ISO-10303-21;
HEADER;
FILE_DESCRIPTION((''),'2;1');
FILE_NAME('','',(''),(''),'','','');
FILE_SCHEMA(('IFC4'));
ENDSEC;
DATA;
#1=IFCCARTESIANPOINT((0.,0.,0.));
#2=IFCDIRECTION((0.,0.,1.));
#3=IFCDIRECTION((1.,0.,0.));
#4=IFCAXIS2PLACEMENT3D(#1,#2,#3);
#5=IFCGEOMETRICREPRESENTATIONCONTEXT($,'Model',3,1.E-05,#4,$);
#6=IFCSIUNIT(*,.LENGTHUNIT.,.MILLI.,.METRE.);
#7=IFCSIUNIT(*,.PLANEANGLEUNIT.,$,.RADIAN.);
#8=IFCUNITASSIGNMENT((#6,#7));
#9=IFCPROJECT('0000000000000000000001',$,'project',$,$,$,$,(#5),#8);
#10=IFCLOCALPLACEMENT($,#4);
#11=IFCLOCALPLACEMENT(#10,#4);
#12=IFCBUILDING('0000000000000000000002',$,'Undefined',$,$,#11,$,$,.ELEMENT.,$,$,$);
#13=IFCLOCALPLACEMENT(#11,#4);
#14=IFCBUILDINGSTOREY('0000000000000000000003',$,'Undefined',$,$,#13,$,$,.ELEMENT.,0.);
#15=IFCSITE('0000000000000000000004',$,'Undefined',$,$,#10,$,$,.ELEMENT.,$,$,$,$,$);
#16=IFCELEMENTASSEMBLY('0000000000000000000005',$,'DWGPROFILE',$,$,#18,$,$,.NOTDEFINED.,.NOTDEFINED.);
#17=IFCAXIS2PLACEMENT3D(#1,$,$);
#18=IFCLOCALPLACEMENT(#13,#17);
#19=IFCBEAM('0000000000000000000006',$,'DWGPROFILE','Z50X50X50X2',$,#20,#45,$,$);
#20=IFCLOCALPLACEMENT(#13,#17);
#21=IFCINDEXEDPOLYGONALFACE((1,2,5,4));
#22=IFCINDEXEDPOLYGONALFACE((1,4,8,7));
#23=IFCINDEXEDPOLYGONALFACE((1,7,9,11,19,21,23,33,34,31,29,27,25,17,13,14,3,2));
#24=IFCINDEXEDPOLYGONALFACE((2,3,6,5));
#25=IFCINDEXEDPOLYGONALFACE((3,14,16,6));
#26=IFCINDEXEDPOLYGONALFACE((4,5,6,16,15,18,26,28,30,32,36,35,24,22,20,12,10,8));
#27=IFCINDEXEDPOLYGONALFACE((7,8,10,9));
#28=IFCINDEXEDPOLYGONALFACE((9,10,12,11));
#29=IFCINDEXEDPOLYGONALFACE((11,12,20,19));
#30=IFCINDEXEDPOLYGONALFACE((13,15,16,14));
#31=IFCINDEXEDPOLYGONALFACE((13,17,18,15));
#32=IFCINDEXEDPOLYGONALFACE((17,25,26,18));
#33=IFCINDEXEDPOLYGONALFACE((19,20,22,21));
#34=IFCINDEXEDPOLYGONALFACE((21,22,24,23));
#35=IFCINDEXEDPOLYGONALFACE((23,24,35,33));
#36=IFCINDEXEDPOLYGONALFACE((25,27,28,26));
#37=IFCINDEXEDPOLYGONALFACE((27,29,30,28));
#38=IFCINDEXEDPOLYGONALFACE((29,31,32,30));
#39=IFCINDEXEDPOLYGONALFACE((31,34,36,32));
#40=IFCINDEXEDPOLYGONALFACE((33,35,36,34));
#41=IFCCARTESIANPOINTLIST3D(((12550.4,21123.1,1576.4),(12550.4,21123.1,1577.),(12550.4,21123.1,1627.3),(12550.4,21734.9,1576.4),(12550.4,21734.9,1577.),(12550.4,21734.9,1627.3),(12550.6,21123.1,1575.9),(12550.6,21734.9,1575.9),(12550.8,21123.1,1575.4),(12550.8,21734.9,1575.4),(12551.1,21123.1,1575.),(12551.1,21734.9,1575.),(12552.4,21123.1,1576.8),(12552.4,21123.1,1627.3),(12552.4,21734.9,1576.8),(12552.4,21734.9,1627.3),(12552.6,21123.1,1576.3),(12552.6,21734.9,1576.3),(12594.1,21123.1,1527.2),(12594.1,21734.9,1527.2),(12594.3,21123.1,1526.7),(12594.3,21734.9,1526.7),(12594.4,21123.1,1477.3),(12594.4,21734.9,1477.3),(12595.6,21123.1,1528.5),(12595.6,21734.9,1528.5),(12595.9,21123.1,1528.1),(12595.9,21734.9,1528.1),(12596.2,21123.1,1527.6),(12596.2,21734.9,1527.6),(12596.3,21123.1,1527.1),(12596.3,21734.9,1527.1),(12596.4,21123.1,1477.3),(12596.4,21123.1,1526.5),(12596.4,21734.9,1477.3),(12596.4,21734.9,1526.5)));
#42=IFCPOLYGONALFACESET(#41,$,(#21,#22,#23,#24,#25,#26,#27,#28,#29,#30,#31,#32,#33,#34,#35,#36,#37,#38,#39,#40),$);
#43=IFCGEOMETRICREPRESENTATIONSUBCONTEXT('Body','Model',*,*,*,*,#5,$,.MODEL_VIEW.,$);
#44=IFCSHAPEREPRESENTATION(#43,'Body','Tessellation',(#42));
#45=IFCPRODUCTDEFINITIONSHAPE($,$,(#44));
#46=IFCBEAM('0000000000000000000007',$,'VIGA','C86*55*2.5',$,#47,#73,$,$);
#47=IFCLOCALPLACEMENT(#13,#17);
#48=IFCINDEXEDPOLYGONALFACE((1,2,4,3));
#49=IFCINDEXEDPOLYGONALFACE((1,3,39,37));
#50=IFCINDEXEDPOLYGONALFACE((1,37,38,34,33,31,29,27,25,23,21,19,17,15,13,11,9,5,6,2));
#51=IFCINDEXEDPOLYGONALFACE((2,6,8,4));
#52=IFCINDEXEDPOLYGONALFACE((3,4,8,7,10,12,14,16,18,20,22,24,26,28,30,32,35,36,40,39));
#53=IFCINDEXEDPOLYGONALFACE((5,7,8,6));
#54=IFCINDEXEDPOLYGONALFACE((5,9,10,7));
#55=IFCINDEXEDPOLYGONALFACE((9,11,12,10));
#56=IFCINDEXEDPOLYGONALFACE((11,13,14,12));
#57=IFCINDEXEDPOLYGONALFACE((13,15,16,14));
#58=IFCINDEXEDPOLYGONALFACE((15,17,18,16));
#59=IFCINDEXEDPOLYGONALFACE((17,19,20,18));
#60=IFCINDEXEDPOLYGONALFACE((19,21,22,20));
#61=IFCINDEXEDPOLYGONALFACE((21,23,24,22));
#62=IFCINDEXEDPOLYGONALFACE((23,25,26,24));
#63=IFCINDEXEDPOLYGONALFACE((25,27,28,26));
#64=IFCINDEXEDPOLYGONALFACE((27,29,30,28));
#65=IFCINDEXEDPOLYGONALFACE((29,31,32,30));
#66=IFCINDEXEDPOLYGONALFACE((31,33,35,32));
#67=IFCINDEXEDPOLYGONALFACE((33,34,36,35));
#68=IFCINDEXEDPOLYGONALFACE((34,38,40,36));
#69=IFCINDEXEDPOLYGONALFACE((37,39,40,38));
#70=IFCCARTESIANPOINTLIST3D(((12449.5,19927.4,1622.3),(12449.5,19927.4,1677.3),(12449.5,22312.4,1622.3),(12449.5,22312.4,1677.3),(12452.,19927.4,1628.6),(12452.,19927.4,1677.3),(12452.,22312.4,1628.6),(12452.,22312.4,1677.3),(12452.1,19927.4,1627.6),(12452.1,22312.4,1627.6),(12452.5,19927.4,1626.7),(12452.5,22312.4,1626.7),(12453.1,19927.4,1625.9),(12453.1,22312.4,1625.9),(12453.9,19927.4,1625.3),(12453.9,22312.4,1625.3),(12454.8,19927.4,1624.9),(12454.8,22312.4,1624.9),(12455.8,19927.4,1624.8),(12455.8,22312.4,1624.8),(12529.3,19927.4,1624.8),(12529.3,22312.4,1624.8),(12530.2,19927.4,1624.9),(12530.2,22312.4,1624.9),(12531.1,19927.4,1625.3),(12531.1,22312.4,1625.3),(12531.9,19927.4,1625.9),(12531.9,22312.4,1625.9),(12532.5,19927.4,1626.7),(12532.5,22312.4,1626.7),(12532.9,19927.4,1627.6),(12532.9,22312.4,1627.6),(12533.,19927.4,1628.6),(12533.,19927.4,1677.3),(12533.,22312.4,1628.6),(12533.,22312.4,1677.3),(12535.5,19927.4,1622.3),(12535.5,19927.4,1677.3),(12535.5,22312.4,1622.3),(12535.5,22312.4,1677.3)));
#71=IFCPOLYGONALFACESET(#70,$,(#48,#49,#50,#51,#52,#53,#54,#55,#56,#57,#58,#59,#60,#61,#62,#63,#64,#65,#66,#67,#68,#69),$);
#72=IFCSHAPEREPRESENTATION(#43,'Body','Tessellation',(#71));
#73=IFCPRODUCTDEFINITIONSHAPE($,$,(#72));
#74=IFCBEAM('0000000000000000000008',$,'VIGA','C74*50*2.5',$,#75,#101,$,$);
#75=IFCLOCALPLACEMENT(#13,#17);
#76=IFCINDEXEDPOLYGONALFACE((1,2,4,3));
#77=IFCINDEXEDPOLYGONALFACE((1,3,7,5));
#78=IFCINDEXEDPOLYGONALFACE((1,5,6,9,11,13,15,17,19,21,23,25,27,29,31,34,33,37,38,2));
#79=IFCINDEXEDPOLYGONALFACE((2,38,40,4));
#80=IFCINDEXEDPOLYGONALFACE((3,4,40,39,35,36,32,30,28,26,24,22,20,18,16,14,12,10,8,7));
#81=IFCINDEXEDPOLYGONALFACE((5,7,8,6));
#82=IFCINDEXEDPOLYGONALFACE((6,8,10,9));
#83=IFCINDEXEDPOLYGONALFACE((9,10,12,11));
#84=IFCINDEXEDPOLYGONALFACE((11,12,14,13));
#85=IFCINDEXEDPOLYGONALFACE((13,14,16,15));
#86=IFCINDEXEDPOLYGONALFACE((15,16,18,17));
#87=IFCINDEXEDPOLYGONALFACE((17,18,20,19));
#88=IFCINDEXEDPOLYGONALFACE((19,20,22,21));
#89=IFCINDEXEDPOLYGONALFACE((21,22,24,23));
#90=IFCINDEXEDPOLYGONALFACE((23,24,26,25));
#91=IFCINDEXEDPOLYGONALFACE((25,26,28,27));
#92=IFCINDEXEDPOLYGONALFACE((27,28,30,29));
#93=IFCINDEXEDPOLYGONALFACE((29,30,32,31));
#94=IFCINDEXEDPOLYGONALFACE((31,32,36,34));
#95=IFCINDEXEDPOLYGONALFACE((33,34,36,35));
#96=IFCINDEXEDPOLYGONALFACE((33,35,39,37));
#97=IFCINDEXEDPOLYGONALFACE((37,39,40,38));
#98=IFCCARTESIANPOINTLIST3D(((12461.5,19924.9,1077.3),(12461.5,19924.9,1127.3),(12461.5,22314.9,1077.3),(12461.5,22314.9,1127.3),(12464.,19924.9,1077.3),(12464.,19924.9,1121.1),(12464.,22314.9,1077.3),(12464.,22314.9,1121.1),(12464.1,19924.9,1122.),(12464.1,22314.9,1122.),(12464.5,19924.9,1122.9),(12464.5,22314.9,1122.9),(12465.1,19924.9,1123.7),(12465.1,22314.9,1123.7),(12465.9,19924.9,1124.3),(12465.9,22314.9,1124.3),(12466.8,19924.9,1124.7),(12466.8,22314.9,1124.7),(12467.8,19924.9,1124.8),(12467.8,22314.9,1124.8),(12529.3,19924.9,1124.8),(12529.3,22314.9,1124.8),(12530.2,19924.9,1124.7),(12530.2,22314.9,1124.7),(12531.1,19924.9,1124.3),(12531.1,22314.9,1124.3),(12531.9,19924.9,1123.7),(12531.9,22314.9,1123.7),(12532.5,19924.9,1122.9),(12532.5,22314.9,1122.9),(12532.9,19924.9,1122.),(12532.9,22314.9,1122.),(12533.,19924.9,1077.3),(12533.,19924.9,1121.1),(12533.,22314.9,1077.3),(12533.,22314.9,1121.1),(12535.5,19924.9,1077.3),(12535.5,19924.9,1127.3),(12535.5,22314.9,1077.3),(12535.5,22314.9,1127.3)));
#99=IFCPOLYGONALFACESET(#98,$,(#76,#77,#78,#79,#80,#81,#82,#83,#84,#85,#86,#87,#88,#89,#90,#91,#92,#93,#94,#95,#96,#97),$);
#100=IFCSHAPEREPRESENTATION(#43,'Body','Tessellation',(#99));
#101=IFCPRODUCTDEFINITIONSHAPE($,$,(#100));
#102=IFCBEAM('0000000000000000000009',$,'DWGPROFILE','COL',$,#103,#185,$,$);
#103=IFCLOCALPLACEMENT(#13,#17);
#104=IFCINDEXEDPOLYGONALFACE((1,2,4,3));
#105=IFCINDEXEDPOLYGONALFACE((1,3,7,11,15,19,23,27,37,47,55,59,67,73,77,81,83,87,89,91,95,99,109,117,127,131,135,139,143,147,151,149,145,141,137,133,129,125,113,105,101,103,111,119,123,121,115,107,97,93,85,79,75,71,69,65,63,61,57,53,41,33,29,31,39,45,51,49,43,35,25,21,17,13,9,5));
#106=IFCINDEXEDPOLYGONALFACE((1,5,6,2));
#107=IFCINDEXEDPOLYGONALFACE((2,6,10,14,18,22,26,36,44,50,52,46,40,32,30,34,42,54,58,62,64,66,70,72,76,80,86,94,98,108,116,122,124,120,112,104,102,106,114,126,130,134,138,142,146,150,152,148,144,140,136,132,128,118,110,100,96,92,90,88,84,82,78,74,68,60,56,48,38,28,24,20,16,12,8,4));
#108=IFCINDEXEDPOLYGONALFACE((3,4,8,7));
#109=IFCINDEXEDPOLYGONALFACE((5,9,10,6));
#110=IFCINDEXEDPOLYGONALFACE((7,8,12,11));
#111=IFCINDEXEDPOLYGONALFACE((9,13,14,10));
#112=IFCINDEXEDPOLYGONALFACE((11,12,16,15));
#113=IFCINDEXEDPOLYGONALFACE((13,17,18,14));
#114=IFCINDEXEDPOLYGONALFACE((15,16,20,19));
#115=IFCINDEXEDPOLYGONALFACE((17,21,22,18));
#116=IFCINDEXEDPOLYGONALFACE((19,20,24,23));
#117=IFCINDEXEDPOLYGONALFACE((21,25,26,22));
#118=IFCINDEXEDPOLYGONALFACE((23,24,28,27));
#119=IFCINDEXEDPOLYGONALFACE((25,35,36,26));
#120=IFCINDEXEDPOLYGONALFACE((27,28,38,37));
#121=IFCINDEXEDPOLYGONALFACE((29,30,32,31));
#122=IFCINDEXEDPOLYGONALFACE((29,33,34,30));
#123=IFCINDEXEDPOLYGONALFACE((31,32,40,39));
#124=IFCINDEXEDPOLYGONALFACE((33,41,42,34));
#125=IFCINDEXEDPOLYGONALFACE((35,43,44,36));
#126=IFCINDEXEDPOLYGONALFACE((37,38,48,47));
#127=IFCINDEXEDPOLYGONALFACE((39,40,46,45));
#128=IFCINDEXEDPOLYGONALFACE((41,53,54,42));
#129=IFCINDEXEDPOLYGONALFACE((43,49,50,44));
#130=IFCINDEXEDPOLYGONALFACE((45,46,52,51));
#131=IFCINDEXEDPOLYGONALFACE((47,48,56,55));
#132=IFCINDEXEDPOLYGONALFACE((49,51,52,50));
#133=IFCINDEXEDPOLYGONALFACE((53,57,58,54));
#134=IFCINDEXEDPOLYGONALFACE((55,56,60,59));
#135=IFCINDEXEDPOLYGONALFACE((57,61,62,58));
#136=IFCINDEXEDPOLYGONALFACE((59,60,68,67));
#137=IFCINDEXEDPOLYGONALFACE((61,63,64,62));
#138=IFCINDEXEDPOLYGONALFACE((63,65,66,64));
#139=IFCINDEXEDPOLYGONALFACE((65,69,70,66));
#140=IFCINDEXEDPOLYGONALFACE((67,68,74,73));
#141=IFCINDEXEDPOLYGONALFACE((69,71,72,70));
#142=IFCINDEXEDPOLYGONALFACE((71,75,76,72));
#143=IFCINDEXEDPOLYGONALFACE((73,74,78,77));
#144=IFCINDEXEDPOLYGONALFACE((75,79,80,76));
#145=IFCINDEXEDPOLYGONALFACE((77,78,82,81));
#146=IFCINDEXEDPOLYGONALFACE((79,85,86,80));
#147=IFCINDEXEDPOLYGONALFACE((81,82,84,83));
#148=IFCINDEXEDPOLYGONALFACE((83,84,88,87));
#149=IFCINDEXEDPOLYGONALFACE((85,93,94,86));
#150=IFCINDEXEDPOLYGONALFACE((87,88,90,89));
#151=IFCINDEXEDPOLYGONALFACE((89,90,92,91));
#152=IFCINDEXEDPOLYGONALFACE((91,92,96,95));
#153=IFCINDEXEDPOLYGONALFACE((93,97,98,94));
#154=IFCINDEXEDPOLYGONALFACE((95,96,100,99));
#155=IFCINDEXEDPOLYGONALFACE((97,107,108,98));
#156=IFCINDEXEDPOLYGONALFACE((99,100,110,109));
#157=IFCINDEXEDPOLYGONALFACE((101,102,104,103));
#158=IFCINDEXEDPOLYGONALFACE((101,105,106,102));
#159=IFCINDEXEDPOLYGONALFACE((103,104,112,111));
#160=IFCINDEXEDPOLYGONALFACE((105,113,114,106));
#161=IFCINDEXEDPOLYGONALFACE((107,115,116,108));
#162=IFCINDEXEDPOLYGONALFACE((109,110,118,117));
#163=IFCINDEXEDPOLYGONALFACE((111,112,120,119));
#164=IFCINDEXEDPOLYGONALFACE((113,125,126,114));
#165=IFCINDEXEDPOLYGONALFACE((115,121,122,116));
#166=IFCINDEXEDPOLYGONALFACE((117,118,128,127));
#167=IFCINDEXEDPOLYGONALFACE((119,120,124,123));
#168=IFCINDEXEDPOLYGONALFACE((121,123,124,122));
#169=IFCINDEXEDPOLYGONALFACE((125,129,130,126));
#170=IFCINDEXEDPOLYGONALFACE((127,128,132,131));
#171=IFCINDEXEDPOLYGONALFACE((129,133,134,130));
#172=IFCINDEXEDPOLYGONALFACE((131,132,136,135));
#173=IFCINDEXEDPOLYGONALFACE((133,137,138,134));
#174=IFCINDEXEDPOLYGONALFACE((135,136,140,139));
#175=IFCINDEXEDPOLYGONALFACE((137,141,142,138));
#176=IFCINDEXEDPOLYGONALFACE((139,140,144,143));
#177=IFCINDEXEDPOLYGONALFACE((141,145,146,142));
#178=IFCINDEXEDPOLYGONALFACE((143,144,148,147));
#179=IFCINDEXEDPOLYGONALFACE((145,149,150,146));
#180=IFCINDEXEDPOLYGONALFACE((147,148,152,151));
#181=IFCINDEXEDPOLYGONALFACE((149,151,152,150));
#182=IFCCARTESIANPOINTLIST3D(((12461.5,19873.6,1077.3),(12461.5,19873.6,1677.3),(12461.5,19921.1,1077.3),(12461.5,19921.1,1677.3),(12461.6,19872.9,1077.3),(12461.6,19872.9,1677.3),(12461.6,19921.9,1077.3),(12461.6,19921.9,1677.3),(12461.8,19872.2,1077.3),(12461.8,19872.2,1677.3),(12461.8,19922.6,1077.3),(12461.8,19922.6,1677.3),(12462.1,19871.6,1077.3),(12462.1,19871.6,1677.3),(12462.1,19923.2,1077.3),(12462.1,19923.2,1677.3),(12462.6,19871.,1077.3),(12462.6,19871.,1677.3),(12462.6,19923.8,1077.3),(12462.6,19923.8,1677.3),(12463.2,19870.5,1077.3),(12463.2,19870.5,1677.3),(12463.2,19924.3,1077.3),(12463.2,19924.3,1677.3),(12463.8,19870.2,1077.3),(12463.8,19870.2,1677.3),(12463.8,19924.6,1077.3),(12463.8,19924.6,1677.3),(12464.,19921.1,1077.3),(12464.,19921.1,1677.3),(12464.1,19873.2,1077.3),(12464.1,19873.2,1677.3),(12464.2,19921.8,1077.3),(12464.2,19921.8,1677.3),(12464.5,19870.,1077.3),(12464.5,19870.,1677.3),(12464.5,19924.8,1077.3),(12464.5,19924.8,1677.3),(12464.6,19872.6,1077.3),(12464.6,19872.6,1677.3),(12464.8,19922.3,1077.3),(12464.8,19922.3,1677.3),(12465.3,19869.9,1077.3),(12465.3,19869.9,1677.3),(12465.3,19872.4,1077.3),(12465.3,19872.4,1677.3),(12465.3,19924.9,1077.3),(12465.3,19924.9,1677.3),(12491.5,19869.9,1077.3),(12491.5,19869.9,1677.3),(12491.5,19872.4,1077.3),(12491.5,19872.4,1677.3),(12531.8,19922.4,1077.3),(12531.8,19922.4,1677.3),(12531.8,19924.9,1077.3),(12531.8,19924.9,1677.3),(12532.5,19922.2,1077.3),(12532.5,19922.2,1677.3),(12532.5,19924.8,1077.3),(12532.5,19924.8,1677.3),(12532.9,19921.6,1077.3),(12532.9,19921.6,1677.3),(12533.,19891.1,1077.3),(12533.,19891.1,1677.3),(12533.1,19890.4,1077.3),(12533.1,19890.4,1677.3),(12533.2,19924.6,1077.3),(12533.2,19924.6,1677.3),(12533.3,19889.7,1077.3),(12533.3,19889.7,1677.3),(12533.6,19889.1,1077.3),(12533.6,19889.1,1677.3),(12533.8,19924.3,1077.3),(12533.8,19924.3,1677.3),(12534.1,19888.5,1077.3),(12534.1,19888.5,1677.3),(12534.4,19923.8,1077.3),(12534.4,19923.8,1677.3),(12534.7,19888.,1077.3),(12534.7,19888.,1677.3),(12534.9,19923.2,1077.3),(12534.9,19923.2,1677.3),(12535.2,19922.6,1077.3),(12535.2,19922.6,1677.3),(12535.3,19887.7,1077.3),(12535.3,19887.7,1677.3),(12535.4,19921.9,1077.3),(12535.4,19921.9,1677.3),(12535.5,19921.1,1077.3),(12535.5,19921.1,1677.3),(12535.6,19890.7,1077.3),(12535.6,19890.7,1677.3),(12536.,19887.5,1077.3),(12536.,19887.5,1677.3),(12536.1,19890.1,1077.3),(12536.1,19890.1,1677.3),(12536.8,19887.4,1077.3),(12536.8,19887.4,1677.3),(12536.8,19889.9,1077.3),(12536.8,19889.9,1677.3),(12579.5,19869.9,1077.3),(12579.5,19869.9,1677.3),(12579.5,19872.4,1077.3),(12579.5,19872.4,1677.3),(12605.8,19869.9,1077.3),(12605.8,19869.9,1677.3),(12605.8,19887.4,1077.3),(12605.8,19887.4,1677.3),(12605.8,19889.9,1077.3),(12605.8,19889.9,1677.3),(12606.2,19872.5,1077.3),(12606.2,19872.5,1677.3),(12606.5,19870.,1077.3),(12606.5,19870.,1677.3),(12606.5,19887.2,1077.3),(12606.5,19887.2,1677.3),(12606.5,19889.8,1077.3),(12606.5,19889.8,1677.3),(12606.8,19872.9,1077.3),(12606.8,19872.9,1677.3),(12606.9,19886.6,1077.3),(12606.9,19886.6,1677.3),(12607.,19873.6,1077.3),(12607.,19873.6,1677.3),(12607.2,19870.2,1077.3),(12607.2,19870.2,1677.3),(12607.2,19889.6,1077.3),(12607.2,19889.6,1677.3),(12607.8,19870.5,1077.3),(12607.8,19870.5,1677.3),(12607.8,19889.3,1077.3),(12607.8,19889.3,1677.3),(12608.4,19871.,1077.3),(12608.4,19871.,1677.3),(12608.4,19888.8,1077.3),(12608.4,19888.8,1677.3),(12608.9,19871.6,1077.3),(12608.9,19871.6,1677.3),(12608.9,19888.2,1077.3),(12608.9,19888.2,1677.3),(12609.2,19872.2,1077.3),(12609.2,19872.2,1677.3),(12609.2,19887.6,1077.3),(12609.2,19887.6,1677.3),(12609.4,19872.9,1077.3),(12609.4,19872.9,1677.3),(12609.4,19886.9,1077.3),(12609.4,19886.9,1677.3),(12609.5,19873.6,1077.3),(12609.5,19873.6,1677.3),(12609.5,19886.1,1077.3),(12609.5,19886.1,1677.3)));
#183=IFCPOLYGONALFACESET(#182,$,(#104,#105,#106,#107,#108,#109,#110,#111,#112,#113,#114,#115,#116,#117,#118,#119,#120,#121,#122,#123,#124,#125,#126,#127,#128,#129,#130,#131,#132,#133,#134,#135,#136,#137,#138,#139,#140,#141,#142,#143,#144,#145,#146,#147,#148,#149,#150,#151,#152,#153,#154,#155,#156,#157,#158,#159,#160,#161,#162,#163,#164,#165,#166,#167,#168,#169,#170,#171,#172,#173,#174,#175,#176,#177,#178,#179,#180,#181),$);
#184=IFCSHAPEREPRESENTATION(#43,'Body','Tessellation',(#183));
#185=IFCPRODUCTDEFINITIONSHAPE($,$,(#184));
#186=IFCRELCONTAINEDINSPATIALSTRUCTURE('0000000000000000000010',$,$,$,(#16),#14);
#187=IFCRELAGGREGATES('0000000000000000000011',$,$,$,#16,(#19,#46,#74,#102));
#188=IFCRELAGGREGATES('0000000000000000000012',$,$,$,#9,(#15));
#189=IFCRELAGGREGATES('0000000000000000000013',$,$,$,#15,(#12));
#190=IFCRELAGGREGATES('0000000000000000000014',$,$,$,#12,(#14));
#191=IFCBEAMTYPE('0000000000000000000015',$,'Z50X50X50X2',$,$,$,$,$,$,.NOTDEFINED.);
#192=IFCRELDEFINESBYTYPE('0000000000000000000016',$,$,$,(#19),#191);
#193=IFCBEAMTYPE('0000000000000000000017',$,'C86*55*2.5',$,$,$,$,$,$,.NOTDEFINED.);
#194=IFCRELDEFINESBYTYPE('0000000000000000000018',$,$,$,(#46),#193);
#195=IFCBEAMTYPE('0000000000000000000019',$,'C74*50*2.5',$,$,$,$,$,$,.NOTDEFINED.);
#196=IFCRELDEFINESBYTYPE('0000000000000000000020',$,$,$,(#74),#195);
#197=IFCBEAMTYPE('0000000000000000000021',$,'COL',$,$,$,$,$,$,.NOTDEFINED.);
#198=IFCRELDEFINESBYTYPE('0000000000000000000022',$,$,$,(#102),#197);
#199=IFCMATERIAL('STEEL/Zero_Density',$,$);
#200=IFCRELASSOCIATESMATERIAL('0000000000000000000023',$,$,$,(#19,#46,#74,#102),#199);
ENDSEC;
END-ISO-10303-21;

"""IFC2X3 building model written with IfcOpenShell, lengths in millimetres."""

from ifc_helpers import new_model, si_unit, frame, origin_with_axes, origin_2d_with_axis, place, context, subcontext, project, spatial, polyline, u_section, outline, extrude, material, type_object, element, aggregate, save


model = new_model("IFC2X3")

# Units and contexts
model_context = context("Model", 3, precision=1e-05, world=origin_with_axes())
body_context = subcontext(model_context, "Body", "Model", "MODEL_VIEW")
ifc_project = project(units=[si_unit("LENGTHUNIT", "METRE", prefix="MILLI"), si_unit("PLANEANGLEUNIT", "RADIAN")], contexts=[model_context])

# Site, building, storey
site_placement = place(None, origin_with_axes())
site = spatial("IfcSite", under=ifc_project, at=site_placement, Name="Undefined", CompositionType="ELEMENT")
building_placement = place(site_placement, origin_with_axes())
building = spatial("IfcBuilding", under=site, at=building_placement, Name="Undefined", CompositionType="ELEMENT")
storey_placement = place(building_placement, origin_with_axes())
storey = spatial("IfcBuildingStorey", under=building, at=storey_placement, Name="Undefined", CompositionType="ELEMENT", Elevation=0.0)

# Element assembly, beams
assembly_1_placement = place(storey_placement, origin_with_axes())
assembly_1 = element("IfcElementAssembly", 1, at=assembly_1_placement, inside=storey, Name="DWGPROFILE", AssemblyPlace="NOTDEFINED", PredefinedType="NOTDEFINED")
ifc_material_1 = material(Name="STEEL/Zero_Density")
beam_type_1 = type_object("IfcBeamType", Name="Z50X50X50X2", PredefinedType="NOTDEFINED")
beam_1_placement = place(assembly_1_placement, frame((12573.4, 21123.1, 1552.3), z_axis=(0.0, 0.0, 1.0), x_axis=(0.0, 1.0, 0.0)))
beam_1 = element("IfcBeam", 2, at=beam_1_placement, type_object=beam_type_1, material=ifc_material_1, Name="DWGPROFILE", Description="Z50X50X50X2", context=body_context, shape_type="SweptSolid", body=[
    extrude(outline(polyline([(-22.9, 24.1), (-23.0, 24.7), (-23.0, 75.0), (-21.0, 75.0), (-21.0, 24.5), (-20.7, 24.0), (22.2, -23.8), (22.6, -24.2), (22.8, -24.7), (22.9, -25.2), (23.0, -25.8), (23.0, -75.0), (21.0, -75.0), (21.0, -25.6), (20.7, -25.1), (-22.2, 22.6), (-22.6, 23.1), (-22.8, 23.6), (-22.9, 24.1)])), frame((611.8, 0.0, 0.0), z_axis=(-1.0, 0.0, 0.0), x_axis=(0.0, -1.0, 0.0)), (0.0, 0.0, 1.0), 611.8),
])
beam_type_2 = type_object("IfcBeamType", Name="C86*55*2.5", PredefinedType="NOTDEFINED")
beam_2_placement = place(assembly_1_placement, frame((12492.5, 19927.4, 1649.8), z_axis=(-1.0, 0.0, 0.0), x_axis=(0.0, 1.0, 0.0)))
beam_2 = element("IfcBeam", 3, at=beam_2_placement, type_object=beam_type_2, material=ifc_material_1, Name="VIGA", Description="C86*55*2.5", context=body_context, shape_type="SweptSolid", body=[
    extrude(u_section(Depth=86.0, FlangeWidth=55.0, WebThickness=2.5, FlangeThickness=2.5, FilletRadius=3.8, at=origin_2d_with_axis()), frame((2385.0, 0.0, 0.0), z_axis=(-1.0, 0.0, 0.0), x_axis=(0.0, -1.0, 0.0)), (0.0, 0.0, 1.0), 2385.0),
])
beam_type_3 = type_object("IfcBeamType", Name="C74*50*2.5", PredefinedType="NOTDEFINED")
beam_3_placement = place(assembly_1_placement, frame((12498.5, 19924.9, 1102.3), z_axis=(1.0, 0.0, 0.0), x_axis=(0.0, 1.0, 0.0)))
beam_3 = element("IfcBeam", 4, at=beam_3_placement, type_object=beam_type_3, material=ifc_material_1, Name="VIGA", Description="C74*50*2.5", context=body_context, shape_type="SweptSolid", body=[
    extrude(u_section(Depth=74.0, FlangeWidth=50.0, WebThickness=2.5, FlangeThickness=2.5, FilletRadius=3.8, at=origin_2d_with_axis()), frame((2390.0, 0.0, 0.0), z_axis=(-1.0, 0.0, 0.0), x_axis=(0.0, -1.0, 0.0)), (0.0, 0.0, 1.0), 2390.0),
])
beam_type_4 = type_object("IfcBeamType", Name="COL", PredefinedType="NOTDEFINED")
beam_4_placement = place(assembly_1_placement, frame((12535.5, 19897.4, 1677.3), z_axis=(-1.0, 0.0, 0.0), x_axis=(0.0, 0.000001, -1.0)))
beam_4 = element("IfcBeam", 5, at=beam_4_placement, type_object=beam_type_4, material=ifc_material_1, Name="DWGPROFILE", Description="COL", context=body_context, shape_type="SweptSolid", body=[
    extrude(outline(polyline([(27.5, 70.2), (27.5, 3.8), (27.4, 3.0), (27.2, 2.3), (26.9, 1.7), (26.4, 1.1), (25.8, 0.6), (25.2, 0.3), (24.5, 0.1), (23.8, 0.0), (-6.7, -0.1), (-7.3, -0.6), (-7.5, -1.2), (-7.5, -70.2), (-7.6, -71.0), (-7.8, -71.7), (-8.1, -72.3), (-8.6, -72.9), (-9.2, -73.4), (-9.8, -73.7), (-10.5, -73.9), (-11.2, -74.0), (-23.8, -74.0), (-24.5, -73.9), (-25.2, -73.7), (-25.8, -73.4), (-26.4, -72.9), (-26.9, -72.3), (-27.2, -71.7), (-27.4, -71.0), (-27.5, -70.2), (-27.5, -44.0), (-25.0, -44.0), (-24.9, -70.7), (-24.4, -71.3), (-23.8, -71.5), (-10.8, -71.4), (-10.2, -70.9), (-10.0, -70.2), (-10.0, -1.2), (-9.9, -0.5), (-9.7, 0.2), (-9.4, 0.8), (-8.9, 1.4), (-8.3, 1.9), (-7.7, 2.2), (-7.0, 2.4), (-6.2, 2.5), (24.2, 2.6), (24.8, 3.1), (25.0, 3.8), (24.9, 70.7), (24.4, 71.3), (23.8, 71.5), (-24.2, 71.4), (-24.8, 70.9), (-25.0, 70.2), (-25.0, 44.0), (-27.5, 44.0), (-27.5, 70.2), (-27.4, 71.0), (-27.2, 71.7), (-26.9, 72.3), (-26.4, 72.9), (-25.8, 73.4), (-25.2, 73.7), (-24.5, 73.9), (-23.8, 74.0), (23.8, 74.0), (24.5, 73.9), (25.2, 73.7), (25.8, 73.4), (26.4, 72.9), (26.9, 72.3), (27.2, 71.7), (27.4, 71.0), (27.5, 70.2)])), frame((600.0, 0.0, 0.0), z_axis=(-1.0, 0.0, 0.0), x_axis=(0.0, -1.0, 0.0)), (0.0, 0.0, 1.0), 600.0),
])

aggregate(assembly_1, [beam_1, beam_2, beam_3, beam_4])

save(model, "model.ifc")
